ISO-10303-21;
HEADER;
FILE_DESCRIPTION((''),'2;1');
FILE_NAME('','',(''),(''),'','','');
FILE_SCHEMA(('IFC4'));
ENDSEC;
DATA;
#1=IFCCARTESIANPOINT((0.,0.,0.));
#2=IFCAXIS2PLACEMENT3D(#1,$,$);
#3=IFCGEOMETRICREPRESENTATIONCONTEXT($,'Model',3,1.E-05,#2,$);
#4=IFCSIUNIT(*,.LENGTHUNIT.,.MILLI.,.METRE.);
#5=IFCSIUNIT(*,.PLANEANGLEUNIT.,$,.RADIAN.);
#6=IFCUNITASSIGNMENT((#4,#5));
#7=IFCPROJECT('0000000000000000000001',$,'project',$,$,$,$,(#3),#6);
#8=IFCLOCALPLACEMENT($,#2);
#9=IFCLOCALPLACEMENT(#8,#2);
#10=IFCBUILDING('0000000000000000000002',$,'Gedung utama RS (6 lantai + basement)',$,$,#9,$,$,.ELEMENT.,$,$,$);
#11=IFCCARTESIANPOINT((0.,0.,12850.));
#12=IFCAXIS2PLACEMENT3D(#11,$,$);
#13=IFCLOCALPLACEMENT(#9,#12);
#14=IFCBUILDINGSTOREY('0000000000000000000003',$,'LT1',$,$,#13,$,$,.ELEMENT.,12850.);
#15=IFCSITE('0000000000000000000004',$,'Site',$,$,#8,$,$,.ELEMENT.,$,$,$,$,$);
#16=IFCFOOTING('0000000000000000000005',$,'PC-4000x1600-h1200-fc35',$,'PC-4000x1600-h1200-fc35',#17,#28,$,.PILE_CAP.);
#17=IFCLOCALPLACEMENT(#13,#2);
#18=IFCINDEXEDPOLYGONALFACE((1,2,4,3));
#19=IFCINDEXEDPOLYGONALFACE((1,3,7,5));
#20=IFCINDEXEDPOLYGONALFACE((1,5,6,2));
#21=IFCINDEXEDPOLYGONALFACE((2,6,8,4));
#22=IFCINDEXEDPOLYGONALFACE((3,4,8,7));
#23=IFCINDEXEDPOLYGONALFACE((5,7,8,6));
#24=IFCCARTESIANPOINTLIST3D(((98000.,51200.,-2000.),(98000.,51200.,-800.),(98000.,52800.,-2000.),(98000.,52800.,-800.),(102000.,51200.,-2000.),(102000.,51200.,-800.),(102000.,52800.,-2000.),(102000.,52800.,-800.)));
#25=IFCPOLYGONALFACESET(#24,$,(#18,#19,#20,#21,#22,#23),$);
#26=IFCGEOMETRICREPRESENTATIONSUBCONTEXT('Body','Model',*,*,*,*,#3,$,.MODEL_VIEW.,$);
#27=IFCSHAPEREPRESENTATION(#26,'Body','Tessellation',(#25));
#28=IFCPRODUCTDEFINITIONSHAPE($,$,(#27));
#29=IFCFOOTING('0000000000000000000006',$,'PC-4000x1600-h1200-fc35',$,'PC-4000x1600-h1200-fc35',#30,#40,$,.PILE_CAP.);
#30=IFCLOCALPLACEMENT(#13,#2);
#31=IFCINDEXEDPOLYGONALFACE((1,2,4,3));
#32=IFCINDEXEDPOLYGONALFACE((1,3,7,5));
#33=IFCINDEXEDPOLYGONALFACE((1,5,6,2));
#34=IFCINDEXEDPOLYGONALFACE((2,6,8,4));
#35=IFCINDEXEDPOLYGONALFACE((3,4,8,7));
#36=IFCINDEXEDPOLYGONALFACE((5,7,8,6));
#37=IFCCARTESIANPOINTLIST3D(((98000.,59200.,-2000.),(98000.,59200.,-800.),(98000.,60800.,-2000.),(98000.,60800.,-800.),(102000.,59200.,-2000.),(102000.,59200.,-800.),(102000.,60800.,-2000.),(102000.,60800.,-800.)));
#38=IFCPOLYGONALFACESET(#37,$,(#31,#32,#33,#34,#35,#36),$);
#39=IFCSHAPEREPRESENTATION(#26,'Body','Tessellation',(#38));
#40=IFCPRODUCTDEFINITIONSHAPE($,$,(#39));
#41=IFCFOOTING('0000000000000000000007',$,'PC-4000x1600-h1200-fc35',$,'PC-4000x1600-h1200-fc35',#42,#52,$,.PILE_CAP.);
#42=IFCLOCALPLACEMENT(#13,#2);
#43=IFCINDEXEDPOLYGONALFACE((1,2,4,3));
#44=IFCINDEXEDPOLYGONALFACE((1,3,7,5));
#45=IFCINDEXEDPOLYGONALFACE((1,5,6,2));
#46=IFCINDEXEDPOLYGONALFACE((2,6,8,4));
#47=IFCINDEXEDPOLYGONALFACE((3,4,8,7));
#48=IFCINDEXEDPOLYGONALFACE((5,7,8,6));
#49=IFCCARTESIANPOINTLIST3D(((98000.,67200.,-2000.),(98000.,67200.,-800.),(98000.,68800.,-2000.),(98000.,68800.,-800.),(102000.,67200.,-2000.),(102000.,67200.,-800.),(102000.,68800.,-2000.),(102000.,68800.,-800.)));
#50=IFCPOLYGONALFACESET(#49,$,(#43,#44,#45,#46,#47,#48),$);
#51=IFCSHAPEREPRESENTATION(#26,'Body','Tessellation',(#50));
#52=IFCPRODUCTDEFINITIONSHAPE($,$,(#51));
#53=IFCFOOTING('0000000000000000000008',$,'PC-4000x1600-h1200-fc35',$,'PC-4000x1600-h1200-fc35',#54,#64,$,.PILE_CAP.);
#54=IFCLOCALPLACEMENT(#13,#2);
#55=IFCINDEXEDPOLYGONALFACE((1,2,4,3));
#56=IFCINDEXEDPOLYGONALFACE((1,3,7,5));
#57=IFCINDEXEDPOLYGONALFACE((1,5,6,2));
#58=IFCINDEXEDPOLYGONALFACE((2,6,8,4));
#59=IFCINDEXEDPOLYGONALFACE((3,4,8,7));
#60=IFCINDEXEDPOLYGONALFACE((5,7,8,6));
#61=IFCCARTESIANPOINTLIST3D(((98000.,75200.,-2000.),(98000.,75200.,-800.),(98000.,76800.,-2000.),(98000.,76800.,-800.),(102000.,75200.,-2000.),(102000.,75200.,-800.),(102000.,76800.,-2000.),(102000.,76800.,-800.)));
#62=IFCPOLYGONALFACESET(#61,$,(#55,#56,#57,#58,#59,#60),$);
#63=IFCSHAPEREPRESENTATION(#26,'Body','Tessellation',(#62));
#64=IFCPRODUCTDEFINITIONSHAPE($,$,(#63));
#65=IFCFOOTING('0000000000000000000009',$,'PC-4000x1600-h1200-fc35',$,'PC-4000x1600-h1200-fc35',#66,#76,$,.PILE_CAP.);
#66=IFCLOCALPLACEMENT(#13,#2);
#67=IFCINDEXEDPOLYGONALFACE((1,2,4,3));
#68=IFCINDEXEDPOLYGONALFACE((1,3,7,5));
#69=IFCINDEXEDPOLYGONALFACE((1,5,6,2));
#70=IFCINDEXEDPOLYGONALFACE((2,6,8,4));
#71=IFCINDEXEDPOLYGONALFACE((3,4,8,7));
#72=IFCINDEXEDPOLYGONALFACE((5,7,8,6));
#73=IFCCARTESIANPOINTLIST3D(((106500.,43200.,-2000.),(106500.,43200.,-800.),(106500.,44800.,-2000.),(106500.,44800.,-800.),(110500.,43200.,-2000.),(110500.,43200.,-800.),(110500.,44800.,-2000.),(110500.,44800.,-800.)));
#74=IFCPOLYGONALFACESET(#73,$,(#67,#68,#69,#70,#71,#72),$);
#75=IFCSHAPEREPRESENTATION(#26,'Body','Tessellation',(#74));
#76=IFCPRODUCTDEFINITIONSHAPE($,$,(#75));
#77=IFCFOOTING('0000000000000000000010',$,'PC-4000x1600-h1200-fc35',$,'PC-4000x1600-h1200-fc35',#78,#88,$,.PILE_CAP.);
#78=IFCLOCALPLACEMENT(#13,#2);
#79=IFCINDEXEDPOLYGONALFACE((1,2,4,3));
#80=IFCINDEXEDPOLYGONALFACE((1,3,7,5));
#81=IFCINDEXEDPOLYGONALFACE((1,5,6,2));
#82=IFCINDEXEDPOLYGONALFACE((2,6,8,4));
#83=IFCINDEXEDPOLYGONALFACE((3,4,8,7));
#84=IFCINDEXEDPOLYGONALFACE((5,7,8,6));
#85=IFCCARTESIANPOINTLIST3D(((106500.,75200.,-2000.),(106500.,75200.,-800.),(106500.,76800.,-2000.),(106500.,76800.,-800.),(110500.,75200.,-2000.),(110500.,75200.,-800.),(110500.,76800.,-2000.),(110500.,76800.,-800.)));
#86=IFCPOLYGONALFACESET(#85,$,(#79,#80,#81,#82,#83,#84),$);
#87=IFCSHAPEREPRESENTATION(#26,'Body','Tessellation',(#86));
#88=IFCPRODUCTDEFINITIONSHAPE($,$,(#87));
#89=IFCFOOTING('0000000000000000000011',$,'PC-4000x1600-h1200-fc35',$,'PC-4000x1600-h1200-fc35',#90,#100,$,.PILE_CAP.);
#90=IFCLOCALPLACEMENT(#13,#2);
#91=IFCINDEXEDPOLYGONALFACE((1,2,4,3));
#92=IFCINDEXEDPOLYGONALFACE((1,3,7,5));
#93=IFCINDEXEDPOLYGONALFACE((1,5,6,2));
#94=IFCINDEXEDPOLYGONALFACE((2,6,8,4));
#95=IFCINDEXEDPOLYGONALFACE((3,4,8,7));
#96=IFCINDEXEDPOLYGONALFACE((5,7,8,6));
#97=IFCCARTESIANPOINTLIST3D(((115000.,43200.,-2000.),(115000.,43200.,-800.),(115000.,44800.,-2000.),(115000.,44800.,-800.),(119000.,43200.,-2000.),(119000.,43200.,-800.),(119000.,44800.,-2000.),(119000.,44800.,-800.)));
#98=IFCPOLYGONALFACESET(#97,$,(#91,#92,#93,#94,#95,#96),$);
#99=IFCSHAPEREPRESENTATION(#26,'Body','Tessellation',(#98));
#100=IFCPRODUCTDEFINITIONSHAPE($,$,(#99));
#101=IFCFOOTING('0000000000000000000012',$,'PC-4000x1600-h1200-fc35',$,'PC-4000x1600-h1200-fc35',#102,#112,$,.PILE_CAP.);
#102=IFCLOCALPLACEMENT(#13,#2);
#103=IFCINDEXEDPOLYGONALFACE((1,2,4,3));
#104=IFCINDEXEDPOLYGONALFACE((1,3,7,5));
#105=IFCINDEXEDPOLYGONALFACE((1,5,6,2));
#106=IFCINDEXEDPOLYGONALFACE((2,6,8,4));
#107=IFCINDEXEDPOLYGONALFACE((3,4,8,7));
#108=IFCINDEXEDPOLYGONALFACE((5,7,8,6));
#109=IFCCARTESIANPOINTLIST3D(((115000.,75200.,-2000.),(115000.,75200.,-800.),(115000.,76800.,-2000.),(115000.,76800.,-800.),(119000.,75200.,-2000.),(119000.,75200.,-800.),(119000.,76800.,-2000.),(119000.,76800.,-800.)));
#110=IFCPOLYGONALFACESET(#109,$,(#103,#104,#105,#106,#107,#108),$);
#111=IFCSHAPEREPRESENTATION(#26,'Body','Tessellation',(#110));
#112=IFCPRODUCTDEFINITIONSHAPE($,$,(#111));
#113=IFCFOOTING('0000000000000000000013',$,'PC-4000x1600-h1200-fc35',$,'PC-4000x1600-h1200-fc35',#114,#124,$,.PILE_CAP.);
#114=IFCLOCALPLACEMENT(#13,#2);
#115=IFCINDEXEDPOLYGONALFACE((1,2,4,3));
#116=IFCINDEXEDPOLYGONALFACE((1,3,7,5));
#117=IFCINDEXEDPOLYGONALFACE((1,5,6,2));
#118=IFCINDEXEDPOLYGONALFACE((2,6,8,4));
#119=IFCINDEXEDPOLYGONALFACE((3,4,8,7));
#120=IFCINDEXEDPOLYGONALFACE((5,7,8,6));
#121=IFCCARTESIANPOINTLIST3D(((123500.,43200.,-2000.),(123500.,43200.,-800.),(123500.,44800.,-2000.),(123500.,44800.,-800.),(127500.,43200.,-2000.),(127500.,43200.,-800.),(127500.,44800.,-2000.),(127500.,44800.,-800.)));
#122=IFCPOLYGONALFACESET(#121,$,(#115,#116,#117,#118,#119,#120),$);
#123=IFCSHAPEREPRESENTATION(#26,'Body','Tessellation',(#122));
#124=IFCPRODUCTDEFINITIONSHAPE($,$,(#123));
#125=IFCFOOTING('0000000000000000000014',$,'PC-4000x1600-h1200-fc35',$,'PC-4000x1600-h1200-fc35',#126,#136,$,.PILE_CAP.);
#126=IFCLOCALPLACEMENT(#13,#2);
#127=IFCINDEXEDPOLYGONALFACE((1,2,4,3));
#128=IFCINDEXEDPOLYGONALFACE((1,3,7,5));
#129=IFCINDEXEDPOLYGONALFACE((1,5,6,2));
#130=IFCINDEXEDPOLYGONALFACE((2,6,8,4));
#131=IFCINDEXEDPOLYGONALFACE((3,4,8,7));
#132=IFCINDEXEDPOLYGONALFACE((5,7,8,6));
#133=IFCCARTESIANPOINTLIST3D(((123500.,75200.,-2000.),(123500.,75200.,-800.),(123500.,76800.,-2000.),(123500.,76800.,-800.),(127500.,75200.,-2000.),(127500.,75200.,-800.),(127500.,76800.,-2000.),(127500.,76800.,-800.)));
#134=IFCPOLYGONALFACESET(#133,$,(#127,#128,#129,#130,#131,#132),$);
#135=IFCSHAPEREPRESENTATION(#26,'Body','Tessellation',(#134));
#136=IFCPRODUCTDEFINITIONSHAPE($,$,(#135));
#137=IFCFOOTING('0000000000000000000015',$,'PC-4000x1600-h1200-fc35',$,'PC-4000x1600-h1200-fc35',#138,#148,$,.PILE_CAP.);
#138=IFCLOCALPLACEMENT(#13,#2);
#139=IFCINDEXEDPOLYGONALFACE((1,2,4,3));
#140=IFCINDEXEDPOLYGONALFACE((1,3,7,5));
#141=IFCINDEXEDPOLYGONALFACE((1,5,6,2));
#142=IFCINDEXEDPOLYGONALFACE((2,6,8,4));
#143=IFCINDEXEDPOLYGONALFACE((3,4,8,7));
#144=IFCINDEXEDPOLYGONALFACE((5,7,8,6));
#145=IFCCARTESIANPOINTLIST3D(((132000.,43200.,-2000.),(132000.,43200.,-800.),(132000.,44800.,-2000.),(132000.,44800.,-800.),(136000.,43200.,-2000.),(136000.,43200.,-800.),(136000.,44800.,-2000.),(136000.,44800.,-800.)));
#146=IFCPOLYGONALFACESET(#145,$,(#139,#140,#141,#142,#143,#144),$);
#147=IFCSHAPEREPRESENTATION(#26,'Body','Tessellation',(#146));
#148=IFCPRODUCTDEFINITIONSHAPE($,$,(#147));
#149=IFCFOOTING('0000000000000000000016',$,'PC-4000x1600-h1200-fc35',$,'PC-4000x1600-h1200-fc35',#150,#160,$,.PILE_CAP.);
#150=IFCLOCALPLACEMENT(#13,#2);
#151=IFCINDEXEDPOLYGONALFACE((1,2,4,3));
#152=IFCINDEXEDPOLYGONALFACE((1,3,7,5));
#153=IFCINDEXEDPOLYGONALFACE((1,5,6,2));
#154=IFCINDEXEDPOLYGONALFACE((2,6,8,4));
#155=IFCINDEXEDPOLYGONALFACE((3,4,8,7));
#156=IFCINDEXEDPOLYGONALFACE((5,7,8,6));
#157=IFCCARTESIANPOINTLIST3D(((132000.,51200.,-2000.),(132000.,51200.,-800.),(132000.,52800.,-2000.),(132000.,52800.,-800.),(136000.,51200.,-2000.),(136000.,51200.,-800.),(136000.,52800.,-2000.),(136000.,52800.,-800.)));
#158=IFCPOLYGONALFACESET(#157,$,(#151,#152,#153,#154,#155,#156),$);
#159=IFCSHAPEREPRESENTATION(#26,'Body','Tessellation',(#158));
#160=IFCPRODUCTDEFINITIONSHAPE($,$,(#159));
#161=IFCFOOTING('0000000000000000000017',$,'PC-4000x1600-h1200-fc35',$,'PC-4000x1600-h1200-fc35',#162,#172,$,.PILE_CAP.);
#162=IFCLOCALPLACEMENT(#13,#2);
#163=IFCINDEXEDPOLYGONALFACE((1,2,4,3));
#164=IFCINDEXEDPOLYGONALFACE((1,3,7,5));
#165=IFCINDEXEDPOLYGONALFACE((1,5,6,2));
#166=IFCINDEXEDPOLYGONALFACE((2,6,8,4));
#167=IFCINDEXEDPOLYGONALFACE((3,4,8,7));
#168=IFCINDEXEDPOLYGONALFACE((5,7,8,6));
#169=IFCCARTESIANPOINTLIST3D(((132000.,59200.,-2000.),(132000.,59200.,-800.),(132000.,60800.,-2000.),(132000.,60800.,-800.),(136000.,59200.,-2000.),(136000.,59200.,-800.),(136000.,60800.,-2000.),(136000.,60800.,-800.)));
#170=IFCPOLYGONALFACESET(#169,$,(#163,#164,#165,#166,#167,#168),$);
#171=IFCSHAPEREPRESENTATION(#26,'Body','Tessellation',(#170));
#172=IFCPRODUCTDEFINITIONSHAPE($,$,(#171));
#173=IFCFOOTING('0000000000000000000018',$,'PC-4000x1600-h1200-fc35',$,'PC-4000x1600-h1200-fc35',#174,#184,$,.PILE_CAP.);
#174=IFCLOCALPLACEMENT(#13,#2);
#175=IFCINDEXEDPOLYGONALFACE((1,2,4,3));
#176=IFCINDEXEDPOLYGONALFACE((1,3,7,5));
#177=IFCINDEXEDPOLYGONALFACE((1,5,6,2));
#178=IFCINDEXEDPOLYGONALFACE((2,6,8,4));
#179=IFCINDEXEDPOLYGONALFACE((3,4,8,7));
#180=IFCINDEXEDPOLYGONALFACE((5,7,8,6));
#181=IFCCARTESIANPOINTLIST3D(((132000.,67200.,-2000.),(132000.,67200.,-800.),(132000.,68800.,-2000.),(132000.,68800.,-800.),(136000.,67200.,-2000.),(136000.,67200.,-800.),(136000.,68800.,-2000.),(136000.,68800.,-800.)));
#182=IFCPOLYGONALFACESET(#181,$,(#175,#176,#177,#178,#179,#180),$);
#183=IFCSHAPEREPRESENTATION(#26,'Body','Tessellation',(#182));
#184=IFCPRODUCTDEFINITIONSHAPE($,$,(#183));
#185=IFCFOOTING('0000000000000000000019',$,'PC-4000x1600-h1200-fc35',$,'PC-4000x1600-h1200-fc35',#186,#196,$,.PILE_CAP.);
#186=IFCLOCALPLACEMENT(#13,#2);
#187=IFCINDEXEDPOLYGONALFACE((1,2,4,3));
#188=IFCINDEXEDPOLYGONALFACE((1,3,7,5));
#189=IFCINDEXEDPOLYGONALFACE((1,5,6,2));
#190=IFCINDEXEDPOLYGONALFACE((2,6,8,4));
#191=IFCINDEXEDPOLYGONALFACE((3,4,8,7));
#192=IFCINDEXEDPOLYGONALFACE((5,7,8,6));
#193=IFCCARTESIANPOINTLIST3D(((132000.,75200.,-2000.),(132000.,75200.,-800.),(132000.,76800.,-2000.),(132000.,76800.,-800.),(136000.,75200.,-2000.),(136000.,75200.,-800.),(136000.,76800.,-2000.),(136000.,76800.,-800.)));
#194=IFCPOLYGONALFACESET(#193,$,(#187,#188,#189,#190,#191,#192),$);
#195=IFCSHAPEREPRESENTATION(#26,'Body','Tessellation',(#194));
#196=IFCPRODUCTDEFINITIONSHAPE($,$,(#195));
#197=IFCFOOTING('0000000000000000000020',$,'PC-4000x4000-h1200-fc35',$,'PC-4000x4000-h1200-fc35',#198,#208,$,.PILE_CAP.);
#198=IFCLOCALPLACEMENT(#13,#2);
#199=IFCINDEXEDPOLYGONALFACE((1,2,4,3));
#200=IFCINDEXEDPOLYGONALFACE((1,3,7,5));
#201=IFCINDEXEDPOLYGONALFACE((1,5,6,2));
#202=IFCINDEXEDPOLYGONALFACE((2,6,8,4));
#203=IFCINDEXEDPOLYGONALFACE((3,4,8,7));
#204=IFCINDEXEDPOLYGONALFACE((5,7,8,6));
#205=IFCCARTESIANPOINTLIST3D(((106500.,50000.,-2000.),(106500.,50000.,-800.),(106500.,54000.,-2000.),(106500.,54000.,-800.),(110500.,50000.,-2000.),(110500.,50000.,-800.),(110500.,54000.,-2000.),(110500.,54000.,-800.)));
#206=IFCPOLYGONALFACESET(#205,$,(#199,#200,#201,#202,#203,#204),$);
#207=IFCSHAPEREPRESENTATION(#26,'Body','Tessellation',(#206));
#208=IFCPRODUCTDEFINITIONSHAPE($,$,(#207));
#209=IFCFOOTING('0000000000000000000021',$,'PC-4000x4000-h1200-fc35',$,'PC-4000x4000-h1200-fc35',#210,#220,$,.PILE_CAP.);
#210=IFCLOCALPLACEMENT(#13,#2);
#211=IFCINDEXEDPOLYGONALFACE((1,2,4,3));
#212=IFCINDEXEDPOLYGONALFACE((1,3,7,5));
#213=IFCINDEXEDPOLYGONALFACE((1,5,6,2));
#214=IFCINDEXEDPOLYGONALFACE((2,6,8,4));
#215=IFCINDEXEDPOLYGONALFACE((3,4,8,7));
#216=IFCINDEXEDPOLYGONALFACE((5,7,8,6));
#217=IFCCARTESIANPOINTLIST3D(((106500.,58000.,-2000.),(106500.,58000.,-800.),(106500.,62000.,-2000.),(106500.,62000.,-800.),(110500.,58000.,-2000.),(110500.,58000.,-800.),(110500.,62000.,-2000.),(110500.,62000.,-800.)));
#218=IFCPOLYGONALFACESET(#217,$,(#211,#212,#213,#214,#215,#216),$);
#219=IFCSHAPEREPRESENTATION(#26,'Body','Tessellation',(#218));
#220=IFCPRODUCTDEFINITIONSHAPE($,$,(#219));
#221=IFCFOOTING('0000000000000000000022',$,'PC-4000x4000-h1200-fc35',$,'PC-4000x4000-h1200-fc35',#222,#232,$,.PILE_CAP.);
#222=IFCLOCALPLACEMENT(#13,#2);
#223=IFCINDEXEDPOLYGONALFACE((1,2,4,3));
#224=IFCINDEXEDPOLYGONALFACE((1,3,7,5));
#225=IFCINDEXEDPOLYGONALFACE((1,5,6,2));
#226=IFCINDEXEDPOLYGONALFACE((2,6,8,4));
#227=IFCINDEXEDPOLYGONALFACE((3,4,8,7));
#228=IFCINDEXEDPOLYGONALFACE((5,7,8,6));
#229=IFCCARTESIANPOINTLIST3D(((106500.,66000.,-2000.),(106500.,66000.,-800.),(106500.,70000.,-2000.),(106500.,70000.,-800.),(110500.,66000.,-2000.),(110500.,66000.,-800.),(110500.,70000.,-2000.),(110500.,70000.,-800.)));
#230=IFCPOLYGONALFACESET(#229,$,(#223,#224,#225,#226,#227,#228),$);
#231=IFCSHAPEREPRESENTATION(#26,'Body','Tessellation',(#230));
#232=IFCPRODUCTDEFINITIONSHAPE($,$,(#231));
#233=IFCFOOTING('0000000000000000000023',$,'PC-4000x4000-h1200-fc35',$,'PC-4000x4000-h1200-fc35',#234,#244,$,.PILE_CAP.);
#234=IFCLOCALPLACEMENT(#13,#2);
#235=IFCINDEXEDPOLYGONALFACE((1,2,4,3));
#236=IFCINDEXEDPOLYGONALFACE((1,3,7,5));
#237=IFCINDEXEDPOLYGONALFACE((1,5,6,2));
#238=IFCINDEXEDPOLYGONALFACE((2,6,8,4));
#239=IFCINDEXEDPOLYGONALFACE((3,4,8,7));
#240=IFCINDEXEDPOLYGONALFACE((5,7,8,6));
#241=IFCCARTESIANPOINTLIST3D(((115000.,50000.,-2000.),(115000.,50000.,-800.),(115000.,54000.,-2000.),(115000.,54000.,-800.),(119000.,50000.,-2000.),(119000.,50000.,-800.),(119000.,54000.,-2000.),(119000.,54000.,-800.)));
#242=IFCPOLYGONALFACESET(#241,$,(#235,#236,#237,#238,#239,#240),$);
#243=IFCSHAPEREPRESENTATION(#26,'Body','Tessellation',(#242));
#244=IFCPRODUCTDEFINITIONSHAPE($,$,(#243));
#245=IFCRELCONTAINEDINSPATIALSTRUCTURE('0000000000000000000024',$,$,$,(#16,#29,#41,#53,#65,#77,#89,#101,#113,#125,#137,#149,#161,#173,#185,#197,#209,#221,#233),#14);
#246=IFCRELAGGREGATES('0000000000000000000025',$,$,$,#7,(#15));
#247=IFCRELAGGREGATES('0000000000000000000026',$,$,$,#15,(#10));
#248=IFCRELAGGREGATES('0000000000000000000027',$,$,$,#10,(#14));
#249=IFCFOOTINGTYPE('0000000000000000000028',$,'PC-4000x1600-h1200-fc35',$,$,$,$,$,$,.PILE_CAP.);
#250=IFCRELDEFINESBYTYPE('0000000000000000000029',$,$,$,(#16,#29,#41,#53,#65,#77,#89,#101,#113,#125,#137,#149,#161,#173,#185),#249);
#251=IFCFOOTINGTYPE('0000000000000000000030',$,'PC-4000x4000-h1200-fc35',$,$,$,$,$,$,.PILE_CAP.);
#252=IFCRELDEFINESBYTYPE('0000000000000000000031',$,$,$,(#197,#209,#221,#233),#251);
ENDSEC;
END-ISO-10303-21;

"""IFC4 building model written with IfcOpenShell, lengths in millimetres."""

from ifc_helpers import new_model, si_unit, frame, origin, origin_2d, place, context, subcontext, project, spatial, rectangle, extrude, material_profile, profile_set, profile_usage, type_object, element, save


model = new_model("IFC4")

# Units and contexts
model_context = context("Model", 3, precision=1e-05, world=origin())
body_context = subcontext(model_context, "Body", "Model", "MODEL_VIEW")
ifc_project = project(units=[si_unit("LENGTHUNIT", "METRE", prefix="MILLI"), si_unit("PLANEANGLEUNIT", "RADIAN")], contexts=[model_context])

# Site, building, storey
site_placement = place(None, origin())
site = spatial("IfcSite", under=ifc_project, at=site_placement, Name="Site", CompositionType="ELEMENT")
building_placement = place(site_placement, origin())
building = spatial("IfcBuilding", under=site, at=building_placement, Name="Gedung utama RS (6 lantai + basement)", CompositionType="ELEMENT")
storey_placement = place(building_placement, frame((0.0, 0.0, 12850.0)))
storey = spatial("IfcBuildingStorey", under=building, at=storey_placement, Name="LT1", CompositionType="ELEMENT", Elevation=12850.0)

# Footings
ifc_material_profile_1 = material_profile(None, rectangle(XDim=4000.0, YDim=1600.0, at=origin_2d()), Name="PC-4000x1600-h1200-fc35")
ifc_profile_set_1 = profile_set([ifc_material_profile_1], Name="PC-4000x1600-h1200-fc35")
ifc_profile_usage_1 = profile_usage(ifc_profile_set_1, cardinal=5)
footing_type_1 = type_object("IfcFootingType", Name="PC-4000x1600-h1200-fc35", PredefinedType="PILE_CAP", material=ifc_profile_set_1)
for number, where, z_axis, x_axis, name in (
    (1, (100000.0, 52000.0, -2000.0), (0.0, 0.0, 1.0), (1.0, 0.0, 0.0), "PC-4000x1600-h1200-fc35"),
    (2, (100000.0, 60000.0, -2000.0), (0.0, 0.0, 1.0), (1.0, 0.0, 0.0), "PC-4000x1600-h1200-fc35"),
    (3, (100000.0, 68000.0, -2000.0), (0.0, 0.0, 1.0), (1.0, 0.0, 0.0), "PC-4000x1600-h1200-fc35"),
    (4, (100000.0, 76000.0, -2000.0), (0.0, 0.0, 1.0), (1.0, 0.0, 0.0), "PC-4000x1600-h1200-fc35"),
    (5, (108500.0, 44000.0, -2000.0), (0.0, 0.0, 1.0), (1.0, 0.0, 0.0), "PC-4000x1600-h1200-fc35"),
    (6, (108500.0, 76000.0, -2000.0), (0.0, 0.0, 1.0), (1.0, 0.0, 0.0), "PC-4000x1600-h1200-fc35"),
    (7, (117000.0, 44000.0, -2000.0), (0.0, 0.0, 1.0), (1.0, 0.0, 0.0), "PC-4000x1600-h1200-fc35"),
    (8, (117000.0, 76000.0, -2000.0), (0.0, 0.0, 1.0), (1.0, 0.0, 0.0), "PC-4000x1600-h1200-fc35"),
    (9, (125500.0, 44000.0, -2000.0), (0.0, 0.0, 1.0), (1.0, 0.0, 0.0), "PC-4000x1600-h1200-fc35"),
    (10, (125500.0, 76000.0, -2000.0), (0.0, 0.0, 1.0), (1.0, 0.0, 0.0), "PC-4000x1600-h1200-fc35"),
    (11, (134000.0, 44000.0, -2000.0), (0.0, 0.0, 1.0), (1.0, 0.0, 0.0), "PC-4000x1600-h1200-fc35"),
    (12, (134000.0, 52000.0, -2000.0), (0.0, 0.0, 1.0), (1.0, 0.0, 0.0), "PC-4000x1600-h1200-fc35"),
    (13, (134000.0, 60000.0, -2000.0), (0.0, 0.0, 1.0), (1.0, 0.0, 0.0), "PC-4000x1600-h1200-fc35"),
    (14, (134000.0, 68000.0, -2000.0), (0.0, 0.0, 1.0), (1.0, 0.0, 0.0), "PC-4000x1600-h1200-fc35"),
    (15, (134000.0, 76000.0, -2000.0), (0.0, 0.0, 1.0), (1.0, 0.0, 0.0), "PC-4000x1600-h1200-fc35"),
):
    element("IfcFooting", number, at=place(storey_placement, frame(where, z_axis=z_axis, x_axis=x_axis)), inside=storey, type_object=footing_type_1, material=ifc_profile_usage_1, Name=name, ObjectType="PC-4000x1600-h1200-fc35", PredefinedType="PILE_CAP", context=body_context, shape_type="SweptSolid", body=[
        extrude(rectangle(XDim=4000.0, YDim=1600.0, at=origin_2d()), origin(), (0.0, 0.0, 1.0), 1200.0),
    ])
ifc_material_profile_2 = material_profile(None, rectangle(XDim=4000.0, YDim=4000.0, at=origin_2d()), Name="PC-4000x4000-h1200-fc35")
ifc_profile_set_2 = profile_set([ifc_material_profile_2], Name="PC-4000x4000-h1200-fc35")
ifc_profile_usage_2 = profile_usage(ifc_profile_set_2, cardinal=5)
footing_type_2 = type_object("IfcFootingType", Name="PC-4000x4000-h1200-fc35", PredefinedType="PILE_CAP", material=ifc_profile_set_2)
for number, where, z_axis, x_axis, name in (
    (16, (108500.0, 52000.0, -2000.0), (0.0, 0.0, 1.0), (1.0, 0.0, 0.0), "PC-4000x4000-h1200-fc35"),
    (17, (108500.0, 60000.0, -2000.0), (0.0, 0.0, 1.0), (1.0, 0.0, 0.0), "PC-4000x4000-h1200-fc35"),
    (18, (108500.0, 68000.0, -2000.0), (0.0, 0.0, 1.0), (1.0, 0.0, 0.0), "PC-4000x4000-h1200-fc35"),
    (19, (117000.0, 52000.0, -2000.0), (0.0, 0.0, 1.0), (1.0, 0.0, 0.0), "PC-4000x4000-h1200-fc35"),
):
    element("IfcFooting", number, at=place(storey_placement, frame(where, z_axis=z_axis, x_axis=x_axis)), inside=storey, type_object=footing_type_2, material=ifc_profile_usage_2, Name=name, ObjectType="PC-4000x4000-h1200-fc35", PredefinedType="PILE_CAP", context=body_context, shape_type="SweptSolid", body=[
        extrude(rectangle(XDim=4000.0, YDim=4000.0, at=origin_2d()), origin(), (0.0, 0.0, 1.0), 1200.0),
    ])

save(model, "model.ifc")
